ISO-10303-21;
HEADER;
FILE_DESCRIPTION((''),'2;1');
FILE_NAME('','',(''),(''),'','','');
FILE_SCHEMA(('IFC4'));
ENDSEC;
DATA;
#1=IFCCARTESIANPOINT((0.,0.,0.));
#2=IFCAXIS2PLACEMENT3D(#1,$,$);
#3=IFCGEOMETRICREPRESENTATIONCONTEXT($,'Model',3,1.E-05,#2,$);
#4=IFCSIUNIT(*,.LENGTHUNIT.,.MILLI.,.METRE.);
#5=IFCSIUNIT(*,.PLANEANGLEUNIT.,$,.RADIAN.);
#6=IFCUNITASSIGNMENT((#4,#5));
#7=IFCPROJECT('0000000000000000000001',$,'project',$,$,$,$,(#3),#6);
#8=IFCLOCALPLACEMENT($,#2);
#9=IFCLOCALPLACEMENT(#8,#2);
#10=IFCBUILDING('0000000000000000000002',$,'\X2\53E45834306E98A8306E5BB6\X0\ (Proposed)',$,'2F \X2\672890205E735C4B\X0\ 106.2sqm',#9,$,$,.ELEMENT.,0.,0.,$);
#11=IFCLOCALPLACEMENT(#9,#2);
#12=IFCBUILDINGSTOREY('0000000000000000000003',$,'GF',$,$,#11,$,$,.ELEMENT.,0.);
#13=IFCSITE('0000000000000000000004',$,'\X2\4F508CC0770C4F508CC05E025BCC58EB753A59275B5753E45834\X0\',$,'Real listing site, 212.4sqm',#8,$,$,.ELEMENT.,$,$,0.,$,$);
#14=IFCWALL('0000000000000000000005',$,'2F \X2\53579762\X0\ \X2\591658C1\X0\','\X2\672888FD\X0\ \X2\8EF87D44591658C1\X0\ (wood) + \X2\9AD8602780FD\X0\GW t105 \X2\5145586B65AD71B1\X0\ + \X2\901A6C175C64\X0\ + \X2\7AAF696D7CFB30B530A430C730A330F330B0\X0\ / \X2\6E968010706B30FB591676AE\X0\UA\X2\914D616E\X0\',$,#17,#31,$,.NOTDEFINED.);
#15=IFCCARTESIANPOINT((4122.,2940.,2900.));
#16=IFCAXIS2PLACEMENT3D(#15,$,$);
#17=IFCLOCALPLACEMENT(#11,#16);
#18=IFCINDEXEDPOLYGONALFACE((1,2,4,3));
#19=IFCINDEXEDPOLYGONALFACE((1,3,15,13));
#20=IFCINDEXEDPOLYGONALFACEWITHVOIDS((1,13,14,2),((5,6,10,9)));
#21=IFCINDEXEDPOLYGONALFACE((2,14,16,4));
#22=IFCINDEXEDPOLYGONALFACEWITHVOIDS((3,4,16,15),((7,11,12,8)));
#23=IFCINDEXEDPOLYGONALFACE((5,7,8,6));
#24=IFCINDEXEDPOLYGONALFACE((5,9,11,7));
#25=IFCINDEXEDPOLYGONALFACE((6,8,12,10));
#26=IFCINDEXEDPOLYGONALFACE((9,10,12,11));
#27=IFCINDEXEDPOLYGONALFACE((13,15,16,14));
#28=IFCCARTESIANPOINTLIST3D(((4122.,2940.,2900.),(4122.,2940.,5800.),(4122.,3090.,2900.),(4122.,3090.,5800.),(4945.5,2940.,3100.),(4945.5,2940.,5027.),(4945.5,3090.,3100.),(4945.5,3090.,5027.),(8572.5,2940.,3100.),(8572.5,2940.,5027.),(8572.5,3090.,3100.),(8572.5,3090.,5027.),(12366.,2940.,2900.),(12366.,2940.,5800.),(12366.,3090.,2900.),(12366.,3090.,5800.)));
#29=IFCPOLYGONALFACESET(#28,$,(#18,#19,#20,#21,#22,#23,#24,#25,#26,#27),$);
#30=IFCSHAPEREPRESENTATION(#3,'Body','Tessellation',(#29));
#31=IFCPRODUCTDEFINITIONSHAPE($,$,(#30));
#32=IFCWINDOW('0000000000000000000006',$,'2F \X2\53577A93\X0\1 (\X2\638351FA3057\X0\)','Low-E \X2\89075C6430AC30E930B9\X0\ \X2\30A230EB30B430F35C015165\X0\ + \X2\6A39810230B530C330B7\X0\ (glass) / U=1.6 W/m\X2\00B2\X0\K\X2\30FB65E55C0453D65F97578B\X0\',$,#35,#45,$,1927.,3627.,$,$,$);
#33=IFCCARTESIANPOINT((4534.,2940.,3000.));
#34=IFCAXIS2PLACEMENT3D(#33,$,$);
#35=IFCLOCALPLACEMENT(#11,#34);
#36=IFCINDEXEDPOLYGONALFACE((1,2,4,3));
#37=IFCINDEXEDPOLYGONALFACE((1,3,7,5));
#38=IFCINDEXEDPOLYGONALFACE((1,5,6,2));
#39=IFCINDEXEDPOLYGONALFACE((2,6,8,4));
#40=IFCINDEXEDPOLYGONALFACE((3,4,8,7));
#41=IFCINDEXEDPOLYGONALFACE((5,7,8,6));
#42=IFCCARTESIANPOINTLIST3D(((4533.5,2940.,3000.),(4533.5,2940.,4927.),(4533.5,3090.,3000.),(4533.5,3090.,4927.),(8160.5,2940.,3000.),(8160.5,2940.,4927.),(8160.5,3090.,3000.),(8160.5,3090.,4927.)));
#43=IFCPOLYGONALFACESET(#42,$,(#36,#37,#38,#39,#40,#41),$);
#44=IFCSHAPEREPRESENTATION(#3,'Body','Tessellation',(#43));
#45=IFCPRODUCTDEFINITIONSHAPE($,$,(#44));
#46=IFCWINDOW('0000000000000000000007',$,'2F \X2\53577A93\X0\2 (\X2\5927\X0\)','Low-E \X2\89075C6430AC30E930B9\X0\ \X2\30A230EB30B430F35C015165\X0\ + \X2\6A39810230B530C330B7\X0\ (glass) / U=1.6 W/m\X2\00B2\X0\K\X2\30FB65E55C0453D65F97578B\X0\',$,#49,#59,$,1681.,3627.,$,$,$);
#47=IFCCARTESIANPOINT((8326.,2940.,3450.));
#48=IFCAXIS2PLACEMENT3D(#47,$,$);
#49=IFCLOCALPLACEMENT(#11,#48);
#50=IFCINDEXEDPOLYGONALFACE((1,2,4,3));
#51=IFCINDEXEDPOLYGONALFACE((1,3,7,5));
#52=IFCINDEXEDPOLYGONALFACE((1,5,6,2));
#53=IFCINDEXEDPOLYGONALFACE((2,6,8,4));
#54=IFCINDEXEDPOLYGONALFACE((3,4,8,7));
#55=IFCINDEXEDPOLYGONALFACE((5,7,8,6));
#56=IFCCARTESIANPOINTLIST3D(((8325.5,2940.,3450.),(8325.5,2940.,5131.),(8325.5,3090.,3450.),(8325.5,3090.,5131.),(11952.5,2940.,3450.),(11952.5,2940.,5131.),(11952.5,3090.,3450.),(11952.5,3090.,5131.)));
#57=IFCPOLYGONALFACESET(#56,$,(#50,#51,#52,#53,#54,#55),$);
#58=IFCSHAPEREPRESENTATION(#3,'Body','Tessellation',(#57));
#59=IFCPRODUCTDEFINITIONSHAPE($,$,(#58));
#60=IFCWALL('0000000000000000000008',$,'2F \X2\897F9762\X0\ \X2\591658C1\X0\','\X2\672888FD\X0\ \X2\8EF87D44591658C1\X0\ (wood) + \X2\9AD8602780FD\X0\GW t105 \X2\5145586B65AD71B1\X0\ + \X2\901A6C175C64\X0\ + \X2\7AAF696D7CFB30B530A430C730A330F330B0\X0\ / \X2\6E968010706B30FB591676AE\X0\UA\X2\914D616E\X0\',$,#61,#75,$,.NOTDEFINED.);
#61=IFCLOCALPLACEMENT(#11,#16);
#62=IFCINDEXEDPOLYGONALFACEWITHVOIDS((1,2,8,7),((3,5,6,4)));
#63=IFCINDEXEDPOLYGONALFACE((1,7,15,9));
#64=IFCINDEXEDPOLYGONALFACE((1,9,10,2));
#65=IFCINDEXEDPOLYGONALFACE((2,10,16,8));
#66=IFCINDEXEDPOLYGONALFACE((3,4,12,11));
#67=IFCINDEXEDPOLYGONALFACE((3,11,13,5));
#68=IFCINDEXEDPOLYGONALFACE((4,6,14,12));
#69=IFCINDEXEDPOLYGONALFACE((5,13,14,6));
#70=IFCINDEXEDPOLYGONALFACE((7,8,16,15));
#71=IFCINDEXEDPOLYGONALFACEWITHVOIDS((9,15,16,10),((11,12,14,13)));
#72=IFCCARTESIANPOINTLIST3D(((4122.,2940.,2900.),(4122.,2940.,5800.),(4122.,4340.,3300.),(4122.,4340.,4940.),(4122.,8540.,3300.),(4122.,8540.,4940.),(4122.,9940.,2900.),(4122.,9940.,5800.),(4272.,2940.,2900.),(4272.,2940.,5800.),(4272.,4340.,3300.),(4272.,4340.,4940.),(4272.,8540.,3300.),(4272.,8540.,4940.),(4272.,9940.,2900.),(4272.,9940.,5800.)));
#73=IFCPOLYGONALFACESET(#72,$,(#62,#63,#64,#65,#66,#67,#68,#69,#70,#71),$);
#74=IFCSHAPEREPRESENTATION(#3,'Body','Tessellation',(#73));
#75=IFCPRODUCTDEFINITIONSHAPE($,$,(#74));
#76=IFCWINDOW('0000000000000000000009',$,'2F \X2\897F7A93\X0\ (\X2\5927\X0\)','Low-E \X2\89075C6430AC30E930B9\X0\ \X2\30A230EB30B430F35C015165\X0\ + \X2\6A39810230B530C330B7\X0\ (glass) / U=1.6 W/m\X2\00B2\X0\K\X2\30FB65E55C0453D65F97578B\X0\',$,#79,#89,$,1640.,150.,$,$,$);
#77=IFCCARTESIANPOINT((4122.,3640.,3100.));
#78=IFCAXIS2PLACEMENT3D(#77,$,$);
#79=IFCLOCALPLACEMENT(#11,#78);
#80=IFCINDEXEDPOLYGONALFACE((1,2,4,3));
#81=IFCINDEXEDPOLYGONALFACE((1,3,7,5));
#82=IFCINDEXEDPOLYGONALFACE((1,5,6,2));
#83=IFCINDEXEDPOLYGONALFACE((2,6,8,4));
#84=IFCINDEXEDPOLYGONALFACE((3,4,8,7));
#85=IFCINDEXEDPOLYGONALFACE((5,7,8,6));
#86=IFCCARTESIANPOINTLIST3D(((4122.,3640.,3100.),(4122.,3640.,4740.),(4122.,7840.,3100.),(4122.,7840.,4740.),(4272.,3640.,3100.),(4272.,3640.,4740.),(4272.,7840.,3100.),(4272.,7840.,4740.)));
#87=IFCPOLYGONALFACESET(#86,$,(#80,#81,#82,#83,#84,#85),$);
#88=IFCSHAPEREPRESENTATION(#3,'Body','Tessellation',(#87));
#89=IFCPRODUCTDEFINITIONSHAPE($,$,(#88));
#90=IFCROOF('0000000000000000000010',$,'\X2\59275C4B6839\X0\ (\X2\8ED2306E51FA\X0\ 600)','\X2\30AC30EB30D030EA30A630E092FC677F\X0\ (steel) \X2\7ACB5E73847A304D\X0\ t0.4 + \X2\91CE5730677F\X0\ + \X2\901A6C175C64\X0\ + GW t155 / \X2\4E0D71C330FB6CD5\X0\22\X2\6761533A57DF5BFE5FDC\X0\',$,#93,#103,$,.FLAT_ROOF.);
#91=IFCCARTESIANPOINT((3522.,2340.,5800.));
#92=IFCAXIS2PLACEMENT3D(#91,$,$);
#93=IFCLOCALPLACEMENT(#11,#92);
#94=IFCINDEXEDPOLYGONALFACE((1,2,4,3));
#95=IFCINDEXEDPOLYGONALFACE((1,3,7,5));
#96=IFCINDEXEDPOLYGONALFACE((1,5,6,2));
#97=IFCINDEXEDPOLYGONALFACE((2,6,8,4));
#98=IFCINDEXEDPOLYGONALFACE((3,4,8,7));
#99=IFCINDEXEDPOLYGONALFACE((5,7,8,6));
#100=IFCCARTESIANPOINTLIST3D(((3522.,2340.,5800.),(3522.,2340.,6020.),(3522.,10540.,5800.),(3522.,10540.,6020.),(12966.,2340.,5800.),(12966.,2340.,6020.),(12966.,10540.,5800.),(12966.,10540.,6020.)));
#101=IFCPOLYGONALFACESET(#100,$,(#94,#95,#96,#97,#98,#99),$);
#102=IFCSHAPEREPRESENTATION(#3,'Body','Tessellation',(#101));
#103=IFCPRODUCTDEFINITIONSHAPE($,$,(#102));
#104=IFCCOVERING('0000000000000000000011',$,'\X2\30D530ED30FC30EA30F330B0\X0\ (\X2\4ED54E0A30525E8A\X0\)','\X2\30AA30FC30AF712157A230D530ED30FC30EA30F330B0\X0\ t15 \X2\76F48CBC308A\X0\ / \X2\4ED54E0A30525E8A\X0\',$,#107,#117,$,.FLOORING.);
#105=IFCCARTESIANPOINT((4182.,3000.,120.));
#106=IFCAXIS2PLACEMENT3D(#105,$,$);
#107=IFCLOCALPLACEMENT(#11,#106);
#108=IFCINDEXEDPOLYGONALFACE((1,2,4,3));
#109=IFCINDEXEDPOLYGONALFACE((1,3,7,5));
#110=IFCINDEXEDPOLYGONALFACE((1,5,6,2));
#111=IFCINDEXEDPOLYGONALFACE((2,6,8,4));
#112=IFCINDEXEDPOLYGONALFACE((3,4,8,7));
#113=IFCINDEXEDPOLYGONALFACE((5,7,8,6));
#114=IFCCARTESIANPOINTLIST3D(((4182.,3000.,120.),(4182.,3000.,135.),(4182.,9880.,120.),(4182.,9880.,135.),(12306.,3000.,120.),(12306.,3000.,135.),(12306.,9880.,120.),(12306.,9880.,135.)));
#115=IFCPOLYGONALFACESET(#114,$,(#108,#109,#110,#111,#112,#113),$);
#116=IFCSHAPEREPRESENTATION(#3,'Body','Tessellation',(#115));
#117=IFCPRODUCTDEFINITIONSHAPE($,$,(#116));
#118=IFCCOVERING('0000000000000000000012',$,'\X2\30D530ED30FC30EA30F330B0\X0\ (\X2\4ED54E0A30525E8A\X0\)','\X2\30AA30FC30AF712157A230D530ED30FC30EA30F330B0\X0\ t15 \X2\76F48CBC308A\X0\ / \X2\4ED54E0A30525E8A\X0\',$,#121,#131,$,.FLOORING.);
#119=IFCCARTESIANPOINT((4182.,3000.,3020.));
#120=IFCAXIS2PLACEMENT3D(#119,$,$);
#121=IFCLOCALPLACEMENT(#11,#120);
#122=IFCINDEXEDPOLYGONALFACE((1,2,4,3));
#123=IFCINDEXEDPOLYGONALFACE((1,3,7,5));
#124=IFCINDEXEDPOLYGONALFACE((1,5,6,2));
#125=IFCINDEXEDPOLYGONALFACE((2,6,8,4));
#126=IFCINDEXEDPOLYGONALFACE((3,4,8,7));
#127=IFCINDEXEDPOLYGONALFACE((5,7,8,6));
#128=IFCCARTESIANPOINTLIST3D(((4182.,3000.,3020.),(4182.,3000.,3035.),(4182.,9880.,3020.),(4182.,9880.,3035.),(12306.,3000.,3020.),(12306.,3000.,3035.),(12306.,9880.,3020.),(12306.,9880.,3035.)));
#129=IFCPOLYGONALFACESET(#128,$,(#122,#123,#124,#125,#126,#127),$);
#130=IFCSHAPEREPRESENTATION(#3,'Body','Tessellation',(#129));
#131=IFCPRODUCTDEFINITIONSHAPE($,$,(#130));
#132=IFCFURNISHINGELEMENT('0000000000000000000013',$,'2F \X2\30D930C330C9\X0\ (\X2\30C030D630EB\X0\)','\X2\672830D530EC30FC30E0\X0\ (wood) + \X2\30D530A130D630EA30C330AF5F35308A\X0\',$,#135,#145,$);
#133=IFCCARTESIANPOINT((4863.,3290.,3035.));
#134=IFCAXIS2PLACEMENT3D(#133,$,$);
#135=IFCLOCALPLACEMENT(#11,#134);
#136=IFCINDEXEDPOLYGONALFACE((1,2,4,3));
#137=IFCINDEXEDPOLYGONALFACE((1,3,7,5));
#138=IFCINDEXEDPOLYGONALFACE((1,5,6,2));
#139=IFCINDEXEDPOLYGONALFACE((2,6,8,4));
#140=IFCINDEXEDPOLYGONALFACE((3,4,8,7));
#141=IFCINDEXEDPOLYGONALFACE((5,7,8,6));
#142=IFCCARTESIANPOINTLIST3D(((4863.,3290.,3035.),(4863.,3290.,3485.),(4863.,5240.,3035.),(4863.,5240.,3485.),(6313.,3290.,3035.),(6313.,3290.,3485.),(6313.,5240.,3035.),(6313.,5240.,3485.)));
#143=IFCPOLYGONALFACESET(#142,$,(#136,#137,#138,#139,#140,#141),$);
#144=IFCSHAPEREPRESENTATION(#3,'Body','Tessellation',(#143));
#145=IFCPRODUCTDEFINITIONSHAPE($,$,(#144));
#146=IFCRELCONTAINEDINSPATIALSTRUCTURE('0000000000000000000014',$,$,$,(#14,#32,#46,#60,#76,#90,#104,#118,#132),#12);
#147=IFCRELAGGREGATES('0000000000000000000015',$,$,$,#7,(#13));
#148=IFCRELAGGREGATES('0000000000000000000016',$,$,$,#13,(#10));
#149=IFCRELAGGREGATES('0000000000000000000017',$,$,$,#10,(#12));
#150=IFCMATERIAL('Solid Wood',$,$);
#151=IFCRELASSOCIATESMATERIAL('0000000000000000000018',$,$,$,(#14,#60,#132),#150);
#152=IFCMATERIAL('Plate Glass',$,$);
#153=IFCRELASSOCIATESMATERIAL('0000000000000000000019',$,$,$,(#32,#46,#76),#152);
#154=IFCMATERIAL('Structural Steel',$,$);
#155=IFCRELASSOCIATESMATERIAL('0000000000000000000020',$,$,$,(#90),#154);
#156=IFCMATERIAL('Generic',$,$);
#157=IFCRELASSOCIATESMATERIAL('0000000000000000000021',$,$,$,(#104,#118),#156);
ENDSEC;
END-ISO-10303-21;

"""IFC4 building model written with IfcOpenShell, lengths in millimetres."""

from ifc_helpers import new_model, si_unit, frame, frame_2d, origin, place, context, project, spatial, rectangle, extrude, material, element, fill, save


model = new_model("IFC4")

# Units and contexts
model_context = context("Model", 3, precision=1e-05, world=origin())
ifc_project = project(units=[si_unit("LENGTHUNIT", "METRE", prefix="MILLI"), si_unit("PLANEANGLEUNIT", "RADIAN")], contexts=[model_context])

# Site, building, storey
site_placement = place(None, origin())
site = spatial("IfcSite", under=ifc_project, at=site_placement, Name="佐賀県佐賀市富士町大字古場", ObjectType="Real listing site, 212.4sqm", CompositionType="ELEMENT", RefElevation=0.0)
building_placement = place(site_placement, origin())
building = spatial("IfcBuilding", under=site, at=building_placement, Name="古場の風の家 (Proposed)", ObjectType="2F 木造平屋 106.2sqm", CompositionType="ELEMENT", ElevationOfRefHeight=0.0, ElevationOfTerrain=0.0)
storey_placement = place(building_placement, origin())
storey = spatial("IfcBuildingStorey", under=building, at=storey_placement, Name="GF", CompositionType="ELEMENT", Elevation=0.0)

# Shared definitions
ifc_material_1 = material(Name="Solid Wood")

# Shared definitions
ifc_material_2 = material(Name="Plate Glass")

# Wall, openings, windows
wall_1_placement = place(storey_placement, frame((4122.0, 2940.0, 2900.0)))
wall_1 = element("IfcWall", 1, at=wall_1_placement, inside=storey, material=ifc_material_1, Name="2F 南面 外壁", Description="木製 軸組外壁 (wood) + 高性能GW t105 充填断熱 + 通気層 + 窯業系サイディング / 準耐火・外皮UA配慮", PredefinedType="NOTDEFINED", context=model_context, shape_type="SweptSolid", body=[
    extrude(rectangle(XDim=8244.0, YDim=150.0, at=frame_2d((4122.0, 75.0))), frame((4122.0, 2940.0, 2900.0)), (0.0, 0.0, 1.0), 2900.0),
])
opening_1_placement = place(storey_placement, frame((4534.0, 2940.0, 3000.0)))
opening_1 = element("IfcOpeningElement", 2, at=opening_1_placement, cuts=wall_1, PredefinedType="NOTDEFINED", context=model_context, shape_type="SweptSolid", body=[
    extrude(rectangle(XDim=3627.0, YDim=150.0, at=frame_2d((1813.0, 75.0))), frame((4534.0, 2940.0, 3000.0)), (0.0, 0.0, 1.0), 1927.0),
])
opening_2_placement = place(storey_placement, frame((8326.0, 2940.0, 3450.0)))
opening_2 = element("IfcOpeningElement", 3, at=opening_2_placement, cuts=wall_1, PredefinedType="NOTDEFINED", context=model_context, shape_type="SweptSolid", body=[
    extrude(rectangle(XDim=3627.0, YDim=150.0, at=frame_2d((1813.0, 75.0))), frame((8326.0, 2940.0, 3450.0)), (0.0, 0.0, 1.0), 1681.0),
])
window_1_placement = place(storey_placement, frame((4534.0, 2940.0, 3000.0)))
window_1 = element("IfcWindow", 4, at=window_1_placement, inside=storey, material=ifc_material_2, Name="2F 南窓1 (掃出し)", Description="Low-E 複層ガラス アルゴン封入 + 樹脂サッシ (glass) / U=1.6 W/m²K・日射取得型", OverallHeight=1927.0, OverallWidth=3627.0, context=model_context, shape_type="SweptSolid", body=[
    extrude(rectangle(XDim=3627.0, YDim=150.0, at=frame_2d((1813.0, 75.0))), frame((4534.0, 2940.0, 3000.0)), (0.0, 0.0, 1.0), 1927.0),
])
fill(opening_1, window_1)
window_2_placement = place(storey_placement, frame((8326.0, 2940.0, 3450.0)))
window_2 = element("IfcWindow", 5, at=window_2_placement, inside=storey, material=ifc_material_2, Name="2F 南窓2 (大)", Description="Low-E 複層ガラス アルゴン封入 + 樹脂サッシ (glass) / U=1.6 W/m²K・日射取得型", OverallHeight=1681.0, OverallWidth=3627.0, context=model_context, shape_type="SweptSolid", body=[
    extrude(rectangle(XDim=3627.0, YDim=150.0, at=frame_2d((1813.0, 75.0))), frame((8326.0, 2940.0, 3450.0)), (0.0, 0.0, 1.0), 1681.0),
])
fill(opening_2, window_2)

# Wall, opening, window
wall_2_placement = place(storey_placement, frame((4122.0, 2940.0, 2900.0)))
wall_2 = element("IfcWall", 6, at=wall_2_placement, inside=storey, material=ifc_material_1, Name="2F 西面 外壁", Description="木製 軸組外壁 (wood) + 高性能GW t105 充填断熱 + 通気層 + 窯業系サイディング / 準耐火・外皮UA配慮", PredefinedType="NOTDEFINED", context=model_context, shape_type="SweptSolid", body=[
    extrude(rectangle(XDim=150.0, YDim=7000.0, at=frame_2d((75.0, 3500.0))), frame((4122.0, 2940.0, 2900.0)), (0.0, 0.0, 1.0), 2900.0),
])
opening_3_placement = place(storey_placement, frame((4122.0, 3640.0, 3100.0)))
opening_3 = element("IfcOpeningElement", 7, at=opening_3_placement, cuts=wall_2, PredefinedType="NOTDEFINED", context=model_context, shape_type="SweptSolid", body=[
    extrude(rectangle(XDim=150.0, YDim=4200.0, at=frame_2d((75.0, 2100.0))), frame((4122.0, 3640.0, 3100.0)), (0.0, 0.0, 1.0), 1640.0),
])
window_3_placement = place(storey_placement, frame((4122.0, 3640.0, 3100.0)))
window_3 = element("IfcWindow", 8, at=window_3_placement, inside=storey, material=ifc_material_2, Name="2F 西窓 (大)", Description="Low-E 複層ガラス アルゴン封入 + 樹脂サッシ (glass) / U=1.6 W/m²K・日射取得型", OverallHeight=1640.0, OverallWidth=150.0, context=model_context, shape_type="SweptSolid", body=[
    extrude(rectangle(XDim=150.0, YDim=4200.0, at=frame_2d((75.0, 2100.0))), frame((4122.0, 3640.0, 3100.0)), (0.0, 0.0, 1.0), 1640.0),
])
fill(opening_3, window_3)

# Roof
ifc_material_3 = material(Name="Structural Steel")
roof_placement = place(storey_placement, frame((3522.0, 2340.0, 5800.0)))
element("IfcRoof", 9, at=roof_placement, inside=storey, material=ifc_material_3, Name="大屋根 (軒の出 600)", Description="ガルバリウム鋼板 (steel) 立平葺き t0.4 + 野地板 + 通気層 + GW t155 / 不燃・法22条区域対応", PredefinedType="FLAT_ROOF", context=model_context, shape_type="SweptSolid", body=[
    extrude(rectangle(XDim=9444.0, YDim=8200.0, at=frame_2d((4722.0, 4100.0))), frame((3522.0, 2340.0, 5800.0)), (0.0, 0.0, 1.0), 220.0),
])

# Coverings
ifc_material_4 = material(Name="Generic")
covering_1_placement = place(storey_placement, frame((4182.0, 3000.0, 120.0)))
element("IfcCovering", 10, at=covering_1_placement, inside=storey, material=ifc_material_4, Name="フローリング (仕上げ床)", Description="オーク無垢フローリング t15 直貼り / 仕上げ床", PredefinedType="FLOORING", context=model_context, shape_type="SweptSolid", body=[
    extrude(rectangle(XDim=8124.0, YDim=6880.0, at=frame_2d((4062.0, 3440.0))), frame((4182.0, 3000.0, 120.0)), (0.0, 0.0, 1.0), 15.0),
])
covering_2_placement = place(storey_placement, frame((4182.0, 3000.0, 3020.0)))
element("IfcCovering", 11, at=covering_2_placement, inside=storey, material=ifc_material_4, Name="フローリング (仕上げ床)", Description="オーク無垢フローリング t15 直貼り / 仕上げ床", PredefinedType="FLOORING", context=model_context, shape_type="SweptSolid", body=[
    extrude(rectangle(XDim=8124.0, YDim=6880.0, at=frame_2d((4062.0, 3440.0))), frame((4182.0, 3000.0, 3020.0)), (0.0, 0.0, 1.0), 15.0),
])

# Furnishing element
furnishing_placement = place(storey_placement, frame((4863.0, 3290.0, 3035.0)))
element("IfcFurnishingElement", 12, at=furnishing_placement, inside=storey, material=ifc_material_1, Name="2F ベッド (ダブル)", Description="木フレーム (wood) + ファブリック張り", context=model_context, shape_type="SweptSolid", body=[
    extrude(rectangle(XDim=1450.0, YDim=1950.0, at=frame_2d((725.0, 975.0))), frame((4863.0, 3290.0, 3035.0)), (0.0, 0.0, 1.0), 450.0),
])

save(model, "model.ifc")
